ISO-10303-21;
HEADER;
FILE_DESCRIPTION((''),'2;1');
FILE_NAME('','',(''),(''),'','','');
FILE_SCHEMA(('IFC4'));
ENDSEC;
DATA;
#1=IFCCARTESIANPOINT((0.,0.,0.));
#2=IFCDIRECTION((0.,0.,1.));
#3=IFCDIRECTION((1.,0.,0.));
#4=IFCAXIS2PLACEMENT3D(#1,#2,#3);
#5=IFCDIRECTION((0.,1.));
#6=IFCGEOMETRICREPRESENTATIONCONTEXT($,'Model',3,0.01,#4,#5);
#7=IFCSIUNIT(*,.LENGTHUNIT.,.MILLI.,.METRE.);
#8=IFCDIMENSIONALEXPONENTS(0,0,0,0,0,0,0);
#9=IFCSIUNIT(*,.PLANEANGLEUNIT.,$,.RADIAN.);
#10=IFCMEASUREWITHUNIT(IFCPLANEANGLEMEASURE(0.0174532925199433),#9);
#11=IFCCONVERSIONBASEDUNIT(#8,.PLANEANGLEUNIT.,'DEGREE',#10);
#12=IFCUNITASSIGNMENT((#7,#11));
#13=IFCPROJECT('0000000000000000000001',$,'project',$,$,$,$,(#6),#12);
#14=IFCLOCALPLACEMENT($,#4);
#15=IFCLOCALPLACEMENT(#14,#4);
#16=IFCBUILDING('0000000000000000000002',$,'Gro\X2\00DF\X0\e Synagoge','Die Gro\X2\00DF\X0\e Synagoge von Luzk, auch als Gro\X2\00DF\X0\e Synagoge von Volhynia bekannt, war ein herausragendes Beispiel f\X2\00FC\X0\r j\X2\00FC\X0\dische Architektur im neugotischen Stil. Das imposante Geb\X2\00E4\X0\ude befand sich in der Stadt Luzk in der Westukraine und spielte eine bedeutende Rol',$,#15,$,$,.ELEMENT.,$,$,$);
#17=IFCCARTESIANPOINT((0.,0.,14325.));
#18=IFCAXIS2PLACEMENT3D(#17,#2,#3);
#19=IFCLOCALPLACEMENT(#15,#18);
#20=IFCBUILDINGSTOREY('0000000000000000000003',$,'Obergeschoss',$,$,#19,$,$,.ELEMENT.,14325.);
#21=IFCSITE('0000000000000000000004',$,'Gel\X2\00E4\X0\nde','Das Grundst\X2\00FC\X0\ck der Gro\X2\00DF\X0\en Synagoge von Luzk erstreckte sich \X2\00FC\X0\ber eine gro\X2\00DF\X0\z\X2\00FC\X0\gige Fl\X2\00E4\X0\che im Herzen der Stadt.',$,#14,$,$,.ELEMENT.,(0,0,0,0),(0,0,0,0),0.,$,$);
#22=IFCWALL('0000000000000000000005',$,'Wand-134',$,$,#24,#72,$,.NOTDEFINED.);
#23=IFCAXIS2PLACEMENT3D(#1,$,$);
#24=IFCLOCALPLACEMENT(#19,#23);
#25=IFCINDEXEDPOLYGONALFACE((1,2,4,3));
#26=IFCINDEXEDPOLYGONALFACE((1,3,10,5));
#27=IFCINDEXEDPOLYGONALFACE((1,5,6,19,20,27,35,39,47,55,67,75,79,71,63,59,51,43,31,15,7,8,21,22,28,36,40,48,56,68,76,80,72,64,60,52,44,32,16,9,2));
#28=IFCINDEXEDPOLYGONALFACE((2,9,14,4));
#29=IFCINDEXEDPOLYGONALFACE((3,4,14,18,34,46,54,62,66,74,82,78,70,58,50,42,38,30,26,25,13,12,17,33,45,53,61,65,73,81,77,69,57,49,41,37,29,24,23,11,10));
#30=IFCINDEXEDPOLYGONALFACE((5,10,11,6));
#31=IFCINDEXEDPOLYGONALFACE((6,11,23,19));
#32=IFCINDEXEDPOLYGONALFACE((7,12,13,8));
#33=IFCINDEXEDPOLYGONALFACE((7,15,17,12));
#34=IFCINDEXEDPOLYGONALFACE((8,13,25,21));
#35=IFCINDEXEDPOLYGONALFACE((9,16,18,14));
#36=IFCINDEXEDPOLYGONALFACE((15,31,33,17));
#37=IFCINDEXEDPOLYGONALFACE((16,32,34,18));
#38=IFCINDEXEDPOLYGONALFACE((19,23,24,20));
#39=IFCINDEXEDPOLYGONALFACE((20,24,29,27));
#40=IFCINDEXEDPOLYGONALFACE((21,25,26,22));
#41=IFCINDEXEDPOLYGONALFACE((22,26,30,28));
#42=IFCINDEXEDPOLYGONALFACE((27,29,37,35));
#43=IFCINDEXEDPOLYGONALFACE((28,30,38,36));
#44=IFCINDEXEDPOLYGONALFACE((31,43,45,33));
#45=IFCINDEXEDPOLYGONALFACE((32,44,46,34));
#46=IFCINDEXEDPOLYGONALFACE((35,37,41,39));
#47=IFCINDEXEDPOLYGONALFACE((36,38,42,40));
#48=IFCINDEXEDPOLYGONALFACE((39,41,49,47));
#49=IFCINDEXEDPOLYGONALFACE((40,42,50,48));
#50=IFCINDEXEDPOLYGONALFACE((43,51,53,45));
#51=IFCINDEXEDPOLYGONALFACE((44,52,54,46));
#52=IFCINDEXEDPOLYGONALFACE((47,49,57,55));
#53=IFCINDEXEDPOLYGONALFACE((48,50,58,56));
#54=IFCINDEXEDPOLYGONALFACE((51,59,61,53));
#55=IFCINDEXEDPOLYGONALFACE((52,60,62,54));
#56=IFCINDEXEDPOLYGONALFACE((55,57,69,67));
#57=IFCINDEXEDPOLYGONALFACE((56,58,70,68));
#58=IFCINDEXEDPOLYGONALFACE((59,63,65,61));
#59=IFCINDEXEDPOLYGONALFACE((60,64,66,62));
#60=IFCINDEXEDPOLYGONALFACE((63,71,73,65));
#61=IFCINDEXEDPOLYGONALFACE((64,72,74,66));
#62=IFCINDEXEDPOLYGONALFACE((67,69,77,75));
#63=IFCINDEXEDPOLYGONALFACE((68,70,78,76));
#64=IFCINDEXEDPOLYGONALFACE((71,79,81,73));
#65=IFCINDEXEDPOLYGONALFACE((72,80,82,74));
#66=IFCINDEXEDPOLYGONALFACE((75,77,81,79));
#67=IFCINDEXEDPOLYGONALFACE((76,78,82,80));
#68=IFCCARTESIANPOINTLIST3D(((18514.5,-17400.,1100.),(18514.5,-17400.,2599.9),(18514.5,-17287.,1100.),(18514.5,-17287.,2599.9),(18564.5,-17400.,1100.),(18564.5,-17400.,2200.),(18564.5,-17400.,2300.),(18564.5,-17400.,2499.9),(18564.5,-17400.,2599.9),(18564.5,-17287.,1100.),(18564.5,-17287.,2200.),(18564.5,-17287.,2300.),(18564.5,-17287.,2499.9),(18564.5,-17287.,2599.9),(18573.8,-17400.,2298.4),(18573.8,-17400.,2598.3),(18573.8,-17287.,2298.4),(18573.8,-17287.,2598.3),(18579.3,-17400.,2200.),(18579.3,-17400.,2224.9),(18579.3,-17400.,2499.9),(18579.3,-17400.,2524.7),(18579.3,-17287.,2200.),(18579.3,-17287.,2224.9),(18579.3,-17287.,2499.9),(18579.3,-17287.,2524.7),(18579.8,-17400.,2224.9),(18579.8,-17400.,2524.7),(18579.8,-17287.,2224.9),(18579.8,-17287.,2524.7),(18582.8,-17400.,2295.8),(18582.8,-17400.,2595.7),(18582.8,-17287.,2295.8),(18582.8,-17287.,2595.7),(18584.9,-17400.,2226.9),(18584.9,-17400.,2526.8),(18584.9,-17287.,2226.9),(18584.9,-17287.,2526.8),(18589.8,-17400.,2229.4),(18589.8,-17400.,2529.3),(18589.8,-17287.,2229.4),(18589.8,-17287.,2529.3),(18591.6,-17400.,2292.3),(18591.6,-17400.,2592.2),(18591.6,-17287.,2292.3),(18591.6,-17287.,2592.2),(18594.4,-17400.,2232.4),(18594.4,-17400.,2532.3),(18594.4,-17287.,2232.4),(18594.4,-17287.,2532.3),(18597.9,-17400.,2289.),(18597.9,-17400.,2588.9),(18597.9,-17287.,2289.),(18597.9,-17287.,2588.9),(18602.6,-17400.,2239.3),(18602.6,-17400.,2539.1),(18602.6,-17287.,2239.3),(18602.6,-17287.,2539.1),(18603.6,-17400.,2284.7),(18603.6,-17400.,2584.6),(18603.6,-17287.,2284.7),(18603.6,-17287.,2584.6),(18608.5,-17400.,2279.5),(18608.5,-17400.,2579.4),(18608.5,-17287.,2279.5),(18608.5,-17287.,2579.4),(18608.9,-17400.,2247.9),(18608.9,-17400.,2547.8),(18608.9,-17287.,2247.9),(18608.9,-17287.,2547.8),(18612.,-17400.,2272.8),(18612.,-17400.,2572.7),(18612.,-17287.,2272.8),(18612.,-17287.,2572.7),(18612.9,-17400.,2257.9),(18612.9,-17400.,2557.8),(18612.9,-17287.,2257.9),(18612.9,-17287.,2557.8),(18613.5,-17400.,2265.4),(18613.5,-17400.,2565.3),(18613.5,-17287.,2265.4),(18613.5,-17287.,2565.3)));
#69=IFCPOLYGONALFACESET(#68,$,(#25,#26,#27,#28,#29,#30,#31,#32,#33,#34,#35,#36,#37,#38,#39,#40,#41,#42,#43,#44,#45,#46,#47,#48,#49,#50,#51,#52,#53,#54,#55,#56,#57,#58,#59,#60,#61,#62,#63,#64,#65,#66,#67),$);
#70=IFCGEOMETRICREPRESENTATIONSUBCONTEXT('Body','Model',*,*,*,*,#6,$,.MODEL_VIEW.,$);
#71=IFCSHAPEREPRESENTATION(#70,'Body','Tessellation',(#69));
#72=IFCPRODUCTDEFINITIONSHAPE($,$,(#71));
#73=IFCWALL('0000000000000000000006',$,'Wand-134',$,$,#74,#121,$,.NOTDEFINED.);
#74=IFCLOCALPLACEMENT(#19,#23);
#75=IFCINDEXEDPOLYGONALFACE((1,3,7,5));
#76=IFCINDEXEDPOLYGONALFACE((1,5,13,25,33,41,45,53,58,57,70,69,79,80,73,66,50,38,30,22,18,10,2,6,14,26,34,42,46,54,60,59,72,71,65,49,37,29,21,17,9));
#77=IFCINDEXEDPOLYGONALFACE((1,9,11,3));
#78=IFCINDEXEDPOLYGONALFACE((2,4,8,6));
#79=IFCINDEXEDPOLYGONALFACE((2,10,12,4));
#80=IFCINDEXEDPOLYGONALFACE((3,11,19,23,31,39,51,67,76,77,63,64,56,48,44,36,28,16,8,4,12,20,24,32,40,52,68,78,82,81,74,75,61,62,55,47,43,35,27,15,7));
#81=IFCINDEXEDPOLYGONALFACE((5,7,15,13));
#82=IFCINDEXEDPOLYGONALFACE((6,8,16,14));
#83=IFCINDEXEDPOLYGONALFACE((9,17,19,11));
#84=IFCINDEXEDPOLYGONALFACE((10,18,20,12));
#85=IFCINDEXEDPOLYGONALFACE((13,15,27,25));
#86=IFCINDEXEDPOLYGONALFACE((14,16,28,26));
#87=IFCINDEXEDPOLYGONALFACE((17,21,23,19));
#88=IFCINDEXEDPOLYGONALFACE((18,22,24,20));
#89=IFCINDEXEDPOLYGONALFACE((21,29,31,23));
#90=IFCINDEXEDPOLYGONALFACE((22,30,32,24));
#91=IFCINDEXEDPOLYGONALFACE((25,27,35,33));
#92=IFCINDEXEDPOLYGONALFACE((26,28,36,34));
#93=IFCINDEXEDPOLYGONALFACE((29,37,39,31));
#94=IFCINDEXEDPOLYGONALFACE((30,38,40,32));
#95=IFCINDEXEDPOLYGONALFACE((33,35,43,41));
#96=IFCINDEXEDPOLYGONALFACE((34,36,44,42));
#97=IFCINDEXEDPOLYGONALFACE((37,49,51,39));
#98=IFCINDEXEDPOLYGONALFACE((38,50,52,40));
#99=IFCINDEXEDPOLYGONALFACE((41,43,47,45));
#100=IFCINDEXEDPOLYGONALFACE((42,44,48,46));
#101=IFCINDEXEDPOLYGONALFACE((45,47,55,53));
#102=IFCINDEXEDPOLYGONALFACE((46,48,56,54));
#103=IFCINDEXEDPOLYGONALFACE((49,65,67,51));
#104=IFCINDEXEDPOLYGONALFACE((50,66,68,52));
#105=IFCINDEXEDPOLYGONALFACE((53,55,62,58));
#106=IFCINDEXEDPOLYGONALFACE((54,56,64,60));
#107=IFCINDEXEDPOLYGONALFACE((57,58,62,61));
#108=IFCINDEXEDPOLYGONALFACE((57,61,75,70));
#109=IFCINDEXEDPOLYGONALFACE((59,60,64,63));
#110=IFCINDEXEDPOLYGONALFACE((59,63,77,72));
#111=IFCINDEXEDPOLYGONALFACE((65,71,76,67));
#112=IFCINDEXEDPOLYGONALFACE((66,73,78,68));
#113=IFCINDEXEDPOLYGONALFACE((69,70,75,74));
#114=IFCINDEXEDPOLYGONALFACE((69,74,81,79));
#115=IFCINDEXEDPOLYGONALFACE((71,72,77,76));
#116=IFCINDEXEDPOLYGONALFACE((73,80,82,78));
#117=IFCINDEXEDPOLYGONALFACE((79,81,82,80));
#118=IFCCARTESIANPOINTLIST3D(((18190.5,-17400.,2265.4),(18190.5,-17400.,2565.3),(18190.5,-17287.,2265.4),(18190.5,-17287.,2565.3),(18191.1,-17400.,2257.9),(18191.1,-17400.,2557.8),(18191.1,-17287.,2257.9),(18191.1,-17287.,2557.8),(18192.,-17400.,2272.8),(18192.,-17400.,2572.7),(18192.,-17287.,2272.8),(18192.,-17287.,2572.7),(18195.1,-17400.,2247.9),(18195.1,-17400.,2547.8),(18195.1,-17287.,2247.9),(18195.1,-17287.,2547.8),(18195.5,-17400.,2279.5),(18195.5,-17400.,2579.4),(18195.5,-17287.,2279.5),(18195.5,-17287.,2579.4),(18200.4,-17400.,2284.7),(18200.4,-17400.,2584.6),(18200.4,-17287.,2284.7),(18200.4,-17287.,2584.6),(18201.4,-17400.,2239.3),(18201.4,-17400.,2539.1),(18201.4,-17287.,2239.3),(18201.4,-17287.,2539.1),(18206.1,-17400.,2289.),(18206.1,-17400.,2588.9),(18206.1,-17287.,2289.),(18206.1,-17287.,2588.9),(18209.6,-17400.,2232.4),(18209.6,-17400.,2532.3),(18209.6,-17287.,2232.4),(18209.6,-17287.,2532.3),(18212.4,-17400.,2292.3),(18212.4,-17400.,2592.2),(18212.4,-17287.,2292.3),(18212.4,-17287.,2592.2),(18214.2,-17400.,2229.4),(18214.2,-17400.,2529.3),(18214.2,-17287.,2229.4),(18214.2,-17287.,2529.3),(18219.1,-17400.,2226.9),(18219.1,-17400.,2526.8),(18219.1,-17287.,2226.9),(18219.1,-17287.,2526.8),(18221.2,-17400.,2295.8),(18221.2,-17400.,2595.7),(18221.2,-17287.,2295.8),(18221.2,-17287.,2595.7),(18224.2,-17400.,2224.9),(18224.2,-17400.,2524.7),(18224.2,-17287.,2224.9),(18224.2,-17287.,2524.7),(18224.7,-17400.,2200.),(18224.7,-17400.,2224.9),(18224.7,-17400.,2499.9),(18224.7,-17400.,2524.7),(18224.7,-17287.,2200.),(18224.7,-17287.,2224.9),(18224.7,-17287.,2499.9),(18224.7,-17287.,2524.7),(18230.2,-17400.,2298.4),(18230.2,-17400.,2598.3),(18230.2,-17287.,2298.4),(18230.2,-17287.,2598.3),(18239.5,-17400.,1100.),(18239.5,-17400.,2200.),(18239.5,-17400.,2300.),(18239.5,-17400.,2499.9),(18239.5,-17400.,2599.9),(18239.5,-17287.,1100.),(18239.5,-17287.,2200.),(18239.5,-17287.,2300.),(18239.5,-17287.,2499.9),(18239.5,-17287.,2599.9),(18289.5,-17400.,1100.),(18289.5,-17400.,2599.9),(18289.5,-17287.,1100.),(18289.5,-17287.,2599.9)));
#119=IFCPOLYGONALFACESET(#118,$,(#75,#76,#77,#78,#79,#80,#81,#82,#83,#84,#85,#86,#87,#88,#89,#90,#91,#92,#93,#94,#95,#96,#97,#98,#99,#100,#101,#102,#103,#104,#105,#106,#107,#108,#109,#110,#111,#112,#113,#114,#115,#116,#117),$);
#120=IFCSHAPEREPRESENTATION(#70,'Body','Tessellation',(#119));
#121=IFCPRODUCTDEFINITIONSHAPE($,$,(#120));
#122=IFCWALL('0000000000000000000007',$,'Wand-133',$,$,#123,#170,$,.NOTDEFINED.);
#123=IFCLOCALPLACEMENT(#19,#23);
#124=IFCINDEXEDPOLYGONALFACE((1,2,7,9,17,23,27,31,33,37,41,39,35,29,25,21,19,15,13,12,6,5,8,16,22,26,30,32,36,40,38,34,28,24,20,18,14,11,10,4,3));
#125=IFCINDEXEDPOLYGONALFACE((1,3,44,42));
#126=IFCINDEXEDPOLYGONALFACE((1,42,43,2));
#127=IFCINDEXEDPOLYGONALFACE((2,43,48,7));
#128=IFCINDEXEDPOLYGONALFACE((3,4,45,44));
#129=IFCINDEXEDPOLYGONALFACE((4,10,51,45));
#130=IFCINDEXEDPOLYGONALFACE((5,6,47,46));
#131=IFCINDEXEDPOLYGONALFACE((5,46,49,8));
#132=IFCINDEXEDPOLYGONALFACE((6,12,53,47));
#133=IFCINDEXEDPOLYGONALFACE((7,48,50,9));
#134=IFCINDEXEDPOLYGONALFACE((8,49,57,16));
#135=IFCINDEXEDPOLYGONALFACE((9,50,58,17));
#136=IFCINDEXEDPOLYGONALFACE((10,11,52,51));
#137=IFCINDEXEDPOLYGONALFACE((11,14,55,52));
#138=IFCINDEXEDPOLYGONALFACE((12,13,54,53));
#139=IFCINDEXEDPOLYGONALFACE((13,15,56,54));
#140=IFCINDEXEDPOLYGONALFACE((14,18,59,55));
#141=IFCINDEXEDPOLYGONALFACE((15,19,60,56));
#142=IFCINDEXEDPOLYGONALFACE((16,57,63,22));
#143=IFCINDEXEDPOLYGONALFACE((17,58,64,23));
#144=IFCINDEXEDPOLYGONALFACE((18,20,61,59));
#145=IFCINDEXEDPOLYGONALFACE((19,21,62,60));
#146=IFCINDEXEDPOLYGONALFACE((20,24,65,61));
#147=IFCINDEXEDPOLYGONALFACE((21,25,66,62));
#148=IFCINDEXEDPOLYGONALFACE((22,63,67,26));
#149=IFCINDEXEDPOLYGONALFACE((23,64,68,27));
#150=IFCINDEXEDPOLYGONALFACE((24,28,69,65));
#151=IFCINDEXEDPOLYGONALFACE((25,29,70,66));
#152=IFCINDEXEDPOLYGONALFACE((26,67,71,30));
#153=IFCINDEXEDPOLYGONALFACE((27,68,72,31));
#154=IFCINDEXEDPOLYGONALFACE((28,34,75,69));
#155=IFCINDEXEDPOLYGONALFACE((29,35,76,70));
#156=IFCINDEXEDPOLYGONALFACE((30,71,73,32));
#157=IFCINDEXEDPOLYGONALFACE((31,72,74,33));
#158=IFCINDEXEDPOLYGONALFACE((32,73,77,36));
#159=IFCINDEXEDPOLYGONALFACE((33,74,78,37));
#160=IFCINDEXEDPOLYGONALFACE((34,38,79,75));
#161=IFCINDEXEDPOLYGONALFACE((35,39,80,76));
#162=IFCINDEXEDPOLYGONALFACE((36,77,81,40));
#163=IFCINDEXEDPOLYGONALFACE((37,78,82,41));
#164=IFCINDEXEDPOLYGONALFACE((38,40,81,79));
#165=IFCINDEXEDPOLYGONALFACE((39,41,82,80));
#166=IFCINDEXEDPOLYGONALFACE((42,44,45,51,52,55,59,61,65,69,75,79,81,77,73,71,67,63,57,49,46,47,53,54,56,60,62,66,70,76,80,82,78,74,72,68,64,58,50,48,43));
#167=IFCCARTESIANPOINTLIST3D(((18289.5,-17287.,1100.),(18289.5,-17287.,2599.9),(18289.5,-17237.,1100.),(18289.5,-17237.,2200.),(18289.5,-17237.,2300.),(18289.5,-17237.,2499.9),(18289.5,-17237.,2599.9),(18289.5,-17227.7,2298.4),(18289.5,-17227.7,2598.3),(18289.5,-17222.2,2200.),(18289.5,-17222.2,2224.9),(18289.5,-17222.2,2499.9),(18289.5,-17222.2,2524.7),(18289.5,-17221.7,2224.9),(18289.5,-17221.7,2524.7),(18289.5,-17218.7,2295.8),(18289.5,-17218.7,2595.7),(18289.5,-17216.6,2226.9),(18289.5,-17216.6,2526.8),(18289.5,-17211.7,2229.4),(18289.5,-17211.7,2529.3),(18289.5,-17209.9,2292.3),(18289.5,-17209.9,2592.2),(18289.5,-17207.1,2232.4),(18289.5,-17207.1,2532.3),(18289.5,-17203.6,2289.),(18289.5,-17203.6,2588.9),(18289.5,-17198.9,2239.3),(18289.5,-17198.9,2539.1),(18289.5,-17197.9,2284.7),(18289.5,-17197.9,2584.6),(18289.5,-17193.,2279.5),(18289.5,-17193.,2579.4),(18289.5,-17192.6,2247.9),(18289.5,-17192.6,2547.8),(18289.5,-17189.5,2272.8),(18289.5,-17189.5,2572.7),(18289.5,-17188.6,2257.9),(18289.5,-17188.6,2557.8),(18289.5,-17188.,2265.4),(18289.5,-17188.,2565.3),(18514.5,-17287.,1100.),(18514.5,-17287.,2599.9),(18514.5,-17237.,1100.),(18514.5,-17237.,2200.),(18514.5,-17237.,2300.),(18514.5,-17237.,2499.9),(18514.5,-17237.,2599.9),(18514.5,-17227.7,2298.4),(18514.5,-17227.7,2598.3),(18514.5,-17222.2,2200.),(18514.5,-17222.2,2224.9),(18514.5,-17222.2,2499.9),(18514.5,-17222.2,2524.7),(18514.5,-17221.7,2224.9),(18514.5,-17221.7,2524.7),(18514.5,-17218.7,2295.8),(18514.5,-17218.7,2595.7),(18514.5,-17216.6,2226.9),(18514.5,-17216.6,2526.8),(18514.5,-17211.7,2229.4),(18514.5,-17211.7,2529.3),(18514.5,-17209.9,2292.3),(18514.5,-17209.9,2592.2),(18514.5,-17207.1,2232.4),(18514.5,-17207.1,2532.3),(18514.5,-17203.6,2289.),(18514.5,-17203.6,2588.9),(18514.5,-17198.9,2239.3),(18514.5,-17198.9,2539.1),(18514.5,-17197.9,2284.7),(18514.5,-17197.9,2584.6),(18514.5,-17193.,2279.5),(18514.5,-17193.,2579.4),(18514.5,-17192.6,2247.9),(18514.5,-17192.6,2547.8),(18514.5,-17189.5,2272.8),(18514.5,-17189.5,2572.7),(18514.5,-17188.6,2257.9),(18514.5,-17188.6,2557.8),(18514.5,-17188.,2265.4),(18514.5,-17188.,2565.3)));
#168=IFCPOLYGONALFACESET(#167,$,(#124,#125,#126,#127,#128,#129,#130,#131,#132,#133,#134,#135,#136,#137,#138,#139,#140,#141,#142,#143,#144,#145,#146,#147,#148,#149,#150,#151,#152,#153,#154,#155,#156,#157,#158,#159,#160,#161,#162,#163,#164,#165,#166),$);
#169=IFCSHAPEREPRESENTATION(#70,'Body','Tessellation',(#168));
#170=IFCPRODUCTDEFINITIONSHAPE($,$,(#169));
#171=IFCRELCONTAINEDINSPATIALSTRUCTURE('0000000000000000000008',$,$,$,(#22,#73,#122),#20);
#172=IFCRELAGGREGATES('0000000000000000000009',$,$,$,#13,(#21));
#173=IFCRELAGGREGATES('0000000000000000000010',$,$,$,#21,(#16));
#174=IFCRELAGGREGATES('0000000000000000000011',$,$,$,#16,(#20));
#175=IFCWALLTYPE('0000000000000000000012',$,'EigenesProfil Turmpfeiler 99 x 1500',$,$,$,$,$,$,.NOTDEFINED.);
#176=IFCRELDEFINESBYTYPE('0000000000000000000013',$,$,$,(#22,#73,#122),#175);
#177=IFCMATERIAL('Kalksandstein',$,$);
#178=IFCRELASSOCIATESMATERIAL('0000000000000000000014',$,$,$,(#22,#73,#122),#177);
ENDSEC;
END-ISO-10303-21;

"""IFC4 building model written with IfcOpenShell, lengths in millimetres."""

from ifc_helpers import new_model, entity, si_unit, converted_unit, direction, frame, origin_with_axes, place, context, subcontext, project, spatial, line, arc, indexed_curve, outline, extrude, material, material_profile, profile_set, type_object, element, save


model = new_model("IFC4")

# Units and contexts
model_context = context("Model", 3, precision=0.01, world=origin_with_axes(), true_north=direction((0.0, 1.0)))
body_context = subcontext(model_context, "Body", "Model", "MODEL_VIEW")
ifc_project = project(units=[si_unit("LENGTHUNIT", "METRE", prefix="MILLI"), converted_unit("PLANEANGLEUNIT", "DEGREE", entity("IfcPlaneAngleMeasure", 0.0174532925199433), si_unit("PLANEANGLEUNIT", "RADIAN"), dimensions=[0, 0, 0, 0, 0, 0, 0])], contexts=[model_context])

# Site, building, storey
site_placement = place(None, origin_with_axes())
site = spatial("IfcSite", under=ifc_project, at=site_placement, Name="Gelände", Description="Das Grundstück der Großen Synagoge von Luzk erstreckte sich über eine großzügige Fläche im Herzen der Stadt.", CompositionType="ELEMENT", RefLatitude=(0, 0, 0, 0), RefLongitude=(0, 0, 0, 0), RefElevation=0.0)
building_placement = place(site_placement, origin_with_axes())
building = spatial("IfcBuilding", under=site, at=building_placement, Name="Große Synagoge", Description="Die Große Synagoge von Luzk, auch als Große Synagoge von Volhynia bekannt, war ein herausragendes Beispiel für jüdische Architektur im neugotischen Stil. Das imposante Gebäude befand sich in der Stadt Luzk in der Westukraine und spielte eine bedeutende Rol", CompositionType="ELEMENT")
storey_placement = place(building_placement, frame((0.0, 0.0, 14325.0), z_axis=(0.0, 0.0, 1.0), x_axis=(1.0, 0.0, 0.0)))
storey = spatial("IfcBuildingStorey", under=building, at=storey_placement, Name="Obergeschoss", CompositionType="ELEMENT", Elevation=14325.0)

# Walls
ifc_material_1 = material(Name="Kalksandstein")
ifc_material_profile = material_profile(ifc_material_1, outline(indexed_curve([(65.3, 1424.7), (72.9, 1428.0), (79.9, 1432.3), (91.6, 1443.3), (98.4, 1457.8), (98.5, 1469.1), (94.0, 1479.4), (86.3, 1486.9), (77.1, 1492.2), (63.8, 1497.1), (50.0, 1499.9), (0.0, 1499.9), (0.0, 0.0), (50.0, 0.0), (50.0, 1100.0), (64.8, 1100.0), (64.8, 1124.9), (65.3, 1124.9), (72.9, 1128.1), (79.9, 1132.4), (91.6, 1143.4), (98.4, 1157.9), (98.5, 1169.2), (94.0, 1179.5), (86.3, 1187.0), (77.1, 1192.3), (63.8, 1197.2), (50.0, 1200.0), (50.0, 1399.9), (64.8, 1399.9), (64.8, 1424.7)], segments=[arc(1, 2, 3), arc(3, 4, 5), arc(5, 6, 7), arc(7, 8, 9), arc(9, 10, 11), line(11, 12, 13, 14, 15, 16, 17, 18), arc(18, 19, 20), arc(20, 21, 22), arc(22, 23, 24), arc(24, 25, 26), arc(26, 27, 28), line(28, 29, 30, 31, 1)])), Name="Kalksandstein")
ifc_profile_set = profile_set([ifc_material_profile], Name="EigenesProfil Turmpfeiler")
wall_type_1 = type_object("IfcWallType", Name="EigenesProfil Turmpfeiler 99 x 1500", PredefinedType="NOTDEFINED")
wall_1_placement = place(storey_placement, frame((18514.5, -17287.0, 1100.0), z_axis=(0.0, 0.0, 1.0), x_axis=(0.0, -1.0, 0.0)))
element("IfcWall", 1, at=wall_1_placement, inside=storey, type_object=wall_type_1, material=ifc_profile_set, Name="Wand-134", PredefinedType="NOTDEFINED", context=body_context, shape_type="SweptSolid", body=[
    extrude(outline(indexed_curve([(65.3, 1424.7), (72.9, 1428.0), (79.9, 1432.3), (91.6, 1443.3), (98.4, 1457.8), (98.5, 1469.1), (94.0, 1479.4), (86.3, 1486.9), (77.1, 1492.2), (63.8, 1497.1), (50.0, 1499.9), (0.0, 1499.9), (0.0, 0.0), (50.0, 0.0), (50.0, 1100.0), (64.8, 1100.0), (64.8, 1124.9), (65.3, 1124.9), (72.9, 1128.1), (79.9, 1132.4), (91.6, 1143.4), (98.4, 1157.9), (98.5, 1169.2), (94.0, 1179.5), (86.3, 1187.0), (77.1, 1192.3), (63.8, 1197.2), (50.0, 1200.0), (50.0, 1399.9), (64.8, 1399.9), (64.8, 1424.7)], segments=[arc(1, 2, 3), arc(3, 4, 5), arc(5, 6, 7), arc(7, 8, 9), arc(9, 10, 11), line(11, 12, 13, 14, 15, 16, 17, 18), arc(18, 19, 20), arc(20, 21, 22), arc(22, 23, 24), arc(24, 25, 26), arc(26, 27, 28), line(28, 29, 30, 31, 1)])), frame((0.0, 0.0, 0.0), z_axis=(1.0, 0.0, 0.0), x_axis=(0.0, 1.0, 0.0)), (0.0, 0.0, 1.0), 113.0),
])
wall_2_placement = place(storey_placement, frame((18289.5, -17287.0, 1100.0), z_axis=(0.0, 0.0, 1.0), x_axis=(0.0, -1.0, 0.0)))
element("IfcWall", 2, at=wall_2_placement, inside=storey, type_object=wall_type_1, material=ifc_profile_set, Name="Wand-134", PredefinedType="NOTDEFINED", context=body_context, shape_type="SweptSolid", body=[
    extrude(outline(indexed_curve([(65.3, 1424.7), (72.9, 1428.0), (79.9, 1432.3), (91.6, 1443.3), (98.4, 1457.8), (98.5, 1469.1), (94.0, 1479.4), (86.3, 1486.9), (77.1, 1492.2), (63.8, 1497.1), (50.0, 1499.9), (0.0, 1499.9), (0.0, 0.0), (50.0, 0.0), (50.0, 1100.0), (64.8, 1100.0), (64.8, 1124.9), (65.3, 1124.9), (72.9, 1128.1), (79.9, 1132.4), (91.6, 1143.4), (98.4, 1157.9), (98.5, 1169.2), (94.0, 1179.5), (86.3, 1187.0), (77.1, 1192.3), (63.8, 1197.2), (50.0, 1200.0), (50.0, 1399.9), (64.8, 1399.9), (64.8, 1424.7)], segments=[arc(1, 2, 3), arc(3, 4, 5), arc(5, 6, 7), arc(7, 8, 9), arc(9, 10, 11), line(11, 12, 13, 14, 15, 16, 17, 18), arc(18, 19, 20), arc(20, 21, 22), arc(22, 23, 24), arc(24, 25, 26), arc(26, 27, 28), line(28, 29, 30, 31, 1)])), frame((0.0, 0.0, 0.0), z_axis=(-1.0, 0.0, 0.0), x_axis=(0.0, -1.0, 0.0)), (0.0, 0.0, -1.0), 113.0),
])
wall_3_placement = place(storey_placement, frame((18289.5, -17287.0, 1100.0), z_axis=(0.0, 0.0, 1.0), x_axis=(1.0, 0.0, 0.0)))
element("IfcWall", 3, at=wall_3_placement, inside=storey, type_object=wall_type_1, material=ifc_profile_set, Name="Wand-133", PredefinedType="NOTDEFINED", context=body_context, shape_type="SweptSolid", body=[
    extrude(outline(indexed_curve([(65.3, 1424.7), (72.9, 1428.0), (79.9, 1432.3), (91.6, 1443.3), (98.4, 1457.8), (98.5, 1469.1), (94.0, 1479.4), (86.3, 1486.9), (77.1, 1492.2), (63.8, 1497.1), (50.0, 1499.9), (0.0, 1499.9), (0.0, 0.0), (50.0, 0.0), (50.0, 1100.0), (64.8, 1100.0), (64.8, 1124.9), (65.3, 1124.9), (72.9, 1128.1), (79.9, 1132.4), (91.6, 1143.4), (98.4, 1157.9), (98.5, 1169.2), (94.0, 1179.5), (86.3, 1187.0), (77.1, 1192.3), (63.8, 1197.2), (50.0, 1200.0), (50.0, 1399.9), (64.8, 1399.9), (64.8, 1424.7)], segments=[arc(1, 2, 3), arc(3, 4, 5), arc(5, 6, 7), arc(7, 8, 9), arc(9, 10, 11), line(11, 12, 13, 14, 15, 16, 17, 18), arc(18, 19, 20), arc(20, 21, 22), arc(22, 23, 24), arc(24, 25, 26), arc(26, 27, 28), line(28, 29, 30, 31, 1)])), frame((0.0, 0.0, 0.0), z_axis=(1.0, 0.0, 0.0), x_axis=(0.0, 1.0, 0.0)), (0.0, 0.0, 1.0), 225.0),
])

save(model, "model.ifc")
